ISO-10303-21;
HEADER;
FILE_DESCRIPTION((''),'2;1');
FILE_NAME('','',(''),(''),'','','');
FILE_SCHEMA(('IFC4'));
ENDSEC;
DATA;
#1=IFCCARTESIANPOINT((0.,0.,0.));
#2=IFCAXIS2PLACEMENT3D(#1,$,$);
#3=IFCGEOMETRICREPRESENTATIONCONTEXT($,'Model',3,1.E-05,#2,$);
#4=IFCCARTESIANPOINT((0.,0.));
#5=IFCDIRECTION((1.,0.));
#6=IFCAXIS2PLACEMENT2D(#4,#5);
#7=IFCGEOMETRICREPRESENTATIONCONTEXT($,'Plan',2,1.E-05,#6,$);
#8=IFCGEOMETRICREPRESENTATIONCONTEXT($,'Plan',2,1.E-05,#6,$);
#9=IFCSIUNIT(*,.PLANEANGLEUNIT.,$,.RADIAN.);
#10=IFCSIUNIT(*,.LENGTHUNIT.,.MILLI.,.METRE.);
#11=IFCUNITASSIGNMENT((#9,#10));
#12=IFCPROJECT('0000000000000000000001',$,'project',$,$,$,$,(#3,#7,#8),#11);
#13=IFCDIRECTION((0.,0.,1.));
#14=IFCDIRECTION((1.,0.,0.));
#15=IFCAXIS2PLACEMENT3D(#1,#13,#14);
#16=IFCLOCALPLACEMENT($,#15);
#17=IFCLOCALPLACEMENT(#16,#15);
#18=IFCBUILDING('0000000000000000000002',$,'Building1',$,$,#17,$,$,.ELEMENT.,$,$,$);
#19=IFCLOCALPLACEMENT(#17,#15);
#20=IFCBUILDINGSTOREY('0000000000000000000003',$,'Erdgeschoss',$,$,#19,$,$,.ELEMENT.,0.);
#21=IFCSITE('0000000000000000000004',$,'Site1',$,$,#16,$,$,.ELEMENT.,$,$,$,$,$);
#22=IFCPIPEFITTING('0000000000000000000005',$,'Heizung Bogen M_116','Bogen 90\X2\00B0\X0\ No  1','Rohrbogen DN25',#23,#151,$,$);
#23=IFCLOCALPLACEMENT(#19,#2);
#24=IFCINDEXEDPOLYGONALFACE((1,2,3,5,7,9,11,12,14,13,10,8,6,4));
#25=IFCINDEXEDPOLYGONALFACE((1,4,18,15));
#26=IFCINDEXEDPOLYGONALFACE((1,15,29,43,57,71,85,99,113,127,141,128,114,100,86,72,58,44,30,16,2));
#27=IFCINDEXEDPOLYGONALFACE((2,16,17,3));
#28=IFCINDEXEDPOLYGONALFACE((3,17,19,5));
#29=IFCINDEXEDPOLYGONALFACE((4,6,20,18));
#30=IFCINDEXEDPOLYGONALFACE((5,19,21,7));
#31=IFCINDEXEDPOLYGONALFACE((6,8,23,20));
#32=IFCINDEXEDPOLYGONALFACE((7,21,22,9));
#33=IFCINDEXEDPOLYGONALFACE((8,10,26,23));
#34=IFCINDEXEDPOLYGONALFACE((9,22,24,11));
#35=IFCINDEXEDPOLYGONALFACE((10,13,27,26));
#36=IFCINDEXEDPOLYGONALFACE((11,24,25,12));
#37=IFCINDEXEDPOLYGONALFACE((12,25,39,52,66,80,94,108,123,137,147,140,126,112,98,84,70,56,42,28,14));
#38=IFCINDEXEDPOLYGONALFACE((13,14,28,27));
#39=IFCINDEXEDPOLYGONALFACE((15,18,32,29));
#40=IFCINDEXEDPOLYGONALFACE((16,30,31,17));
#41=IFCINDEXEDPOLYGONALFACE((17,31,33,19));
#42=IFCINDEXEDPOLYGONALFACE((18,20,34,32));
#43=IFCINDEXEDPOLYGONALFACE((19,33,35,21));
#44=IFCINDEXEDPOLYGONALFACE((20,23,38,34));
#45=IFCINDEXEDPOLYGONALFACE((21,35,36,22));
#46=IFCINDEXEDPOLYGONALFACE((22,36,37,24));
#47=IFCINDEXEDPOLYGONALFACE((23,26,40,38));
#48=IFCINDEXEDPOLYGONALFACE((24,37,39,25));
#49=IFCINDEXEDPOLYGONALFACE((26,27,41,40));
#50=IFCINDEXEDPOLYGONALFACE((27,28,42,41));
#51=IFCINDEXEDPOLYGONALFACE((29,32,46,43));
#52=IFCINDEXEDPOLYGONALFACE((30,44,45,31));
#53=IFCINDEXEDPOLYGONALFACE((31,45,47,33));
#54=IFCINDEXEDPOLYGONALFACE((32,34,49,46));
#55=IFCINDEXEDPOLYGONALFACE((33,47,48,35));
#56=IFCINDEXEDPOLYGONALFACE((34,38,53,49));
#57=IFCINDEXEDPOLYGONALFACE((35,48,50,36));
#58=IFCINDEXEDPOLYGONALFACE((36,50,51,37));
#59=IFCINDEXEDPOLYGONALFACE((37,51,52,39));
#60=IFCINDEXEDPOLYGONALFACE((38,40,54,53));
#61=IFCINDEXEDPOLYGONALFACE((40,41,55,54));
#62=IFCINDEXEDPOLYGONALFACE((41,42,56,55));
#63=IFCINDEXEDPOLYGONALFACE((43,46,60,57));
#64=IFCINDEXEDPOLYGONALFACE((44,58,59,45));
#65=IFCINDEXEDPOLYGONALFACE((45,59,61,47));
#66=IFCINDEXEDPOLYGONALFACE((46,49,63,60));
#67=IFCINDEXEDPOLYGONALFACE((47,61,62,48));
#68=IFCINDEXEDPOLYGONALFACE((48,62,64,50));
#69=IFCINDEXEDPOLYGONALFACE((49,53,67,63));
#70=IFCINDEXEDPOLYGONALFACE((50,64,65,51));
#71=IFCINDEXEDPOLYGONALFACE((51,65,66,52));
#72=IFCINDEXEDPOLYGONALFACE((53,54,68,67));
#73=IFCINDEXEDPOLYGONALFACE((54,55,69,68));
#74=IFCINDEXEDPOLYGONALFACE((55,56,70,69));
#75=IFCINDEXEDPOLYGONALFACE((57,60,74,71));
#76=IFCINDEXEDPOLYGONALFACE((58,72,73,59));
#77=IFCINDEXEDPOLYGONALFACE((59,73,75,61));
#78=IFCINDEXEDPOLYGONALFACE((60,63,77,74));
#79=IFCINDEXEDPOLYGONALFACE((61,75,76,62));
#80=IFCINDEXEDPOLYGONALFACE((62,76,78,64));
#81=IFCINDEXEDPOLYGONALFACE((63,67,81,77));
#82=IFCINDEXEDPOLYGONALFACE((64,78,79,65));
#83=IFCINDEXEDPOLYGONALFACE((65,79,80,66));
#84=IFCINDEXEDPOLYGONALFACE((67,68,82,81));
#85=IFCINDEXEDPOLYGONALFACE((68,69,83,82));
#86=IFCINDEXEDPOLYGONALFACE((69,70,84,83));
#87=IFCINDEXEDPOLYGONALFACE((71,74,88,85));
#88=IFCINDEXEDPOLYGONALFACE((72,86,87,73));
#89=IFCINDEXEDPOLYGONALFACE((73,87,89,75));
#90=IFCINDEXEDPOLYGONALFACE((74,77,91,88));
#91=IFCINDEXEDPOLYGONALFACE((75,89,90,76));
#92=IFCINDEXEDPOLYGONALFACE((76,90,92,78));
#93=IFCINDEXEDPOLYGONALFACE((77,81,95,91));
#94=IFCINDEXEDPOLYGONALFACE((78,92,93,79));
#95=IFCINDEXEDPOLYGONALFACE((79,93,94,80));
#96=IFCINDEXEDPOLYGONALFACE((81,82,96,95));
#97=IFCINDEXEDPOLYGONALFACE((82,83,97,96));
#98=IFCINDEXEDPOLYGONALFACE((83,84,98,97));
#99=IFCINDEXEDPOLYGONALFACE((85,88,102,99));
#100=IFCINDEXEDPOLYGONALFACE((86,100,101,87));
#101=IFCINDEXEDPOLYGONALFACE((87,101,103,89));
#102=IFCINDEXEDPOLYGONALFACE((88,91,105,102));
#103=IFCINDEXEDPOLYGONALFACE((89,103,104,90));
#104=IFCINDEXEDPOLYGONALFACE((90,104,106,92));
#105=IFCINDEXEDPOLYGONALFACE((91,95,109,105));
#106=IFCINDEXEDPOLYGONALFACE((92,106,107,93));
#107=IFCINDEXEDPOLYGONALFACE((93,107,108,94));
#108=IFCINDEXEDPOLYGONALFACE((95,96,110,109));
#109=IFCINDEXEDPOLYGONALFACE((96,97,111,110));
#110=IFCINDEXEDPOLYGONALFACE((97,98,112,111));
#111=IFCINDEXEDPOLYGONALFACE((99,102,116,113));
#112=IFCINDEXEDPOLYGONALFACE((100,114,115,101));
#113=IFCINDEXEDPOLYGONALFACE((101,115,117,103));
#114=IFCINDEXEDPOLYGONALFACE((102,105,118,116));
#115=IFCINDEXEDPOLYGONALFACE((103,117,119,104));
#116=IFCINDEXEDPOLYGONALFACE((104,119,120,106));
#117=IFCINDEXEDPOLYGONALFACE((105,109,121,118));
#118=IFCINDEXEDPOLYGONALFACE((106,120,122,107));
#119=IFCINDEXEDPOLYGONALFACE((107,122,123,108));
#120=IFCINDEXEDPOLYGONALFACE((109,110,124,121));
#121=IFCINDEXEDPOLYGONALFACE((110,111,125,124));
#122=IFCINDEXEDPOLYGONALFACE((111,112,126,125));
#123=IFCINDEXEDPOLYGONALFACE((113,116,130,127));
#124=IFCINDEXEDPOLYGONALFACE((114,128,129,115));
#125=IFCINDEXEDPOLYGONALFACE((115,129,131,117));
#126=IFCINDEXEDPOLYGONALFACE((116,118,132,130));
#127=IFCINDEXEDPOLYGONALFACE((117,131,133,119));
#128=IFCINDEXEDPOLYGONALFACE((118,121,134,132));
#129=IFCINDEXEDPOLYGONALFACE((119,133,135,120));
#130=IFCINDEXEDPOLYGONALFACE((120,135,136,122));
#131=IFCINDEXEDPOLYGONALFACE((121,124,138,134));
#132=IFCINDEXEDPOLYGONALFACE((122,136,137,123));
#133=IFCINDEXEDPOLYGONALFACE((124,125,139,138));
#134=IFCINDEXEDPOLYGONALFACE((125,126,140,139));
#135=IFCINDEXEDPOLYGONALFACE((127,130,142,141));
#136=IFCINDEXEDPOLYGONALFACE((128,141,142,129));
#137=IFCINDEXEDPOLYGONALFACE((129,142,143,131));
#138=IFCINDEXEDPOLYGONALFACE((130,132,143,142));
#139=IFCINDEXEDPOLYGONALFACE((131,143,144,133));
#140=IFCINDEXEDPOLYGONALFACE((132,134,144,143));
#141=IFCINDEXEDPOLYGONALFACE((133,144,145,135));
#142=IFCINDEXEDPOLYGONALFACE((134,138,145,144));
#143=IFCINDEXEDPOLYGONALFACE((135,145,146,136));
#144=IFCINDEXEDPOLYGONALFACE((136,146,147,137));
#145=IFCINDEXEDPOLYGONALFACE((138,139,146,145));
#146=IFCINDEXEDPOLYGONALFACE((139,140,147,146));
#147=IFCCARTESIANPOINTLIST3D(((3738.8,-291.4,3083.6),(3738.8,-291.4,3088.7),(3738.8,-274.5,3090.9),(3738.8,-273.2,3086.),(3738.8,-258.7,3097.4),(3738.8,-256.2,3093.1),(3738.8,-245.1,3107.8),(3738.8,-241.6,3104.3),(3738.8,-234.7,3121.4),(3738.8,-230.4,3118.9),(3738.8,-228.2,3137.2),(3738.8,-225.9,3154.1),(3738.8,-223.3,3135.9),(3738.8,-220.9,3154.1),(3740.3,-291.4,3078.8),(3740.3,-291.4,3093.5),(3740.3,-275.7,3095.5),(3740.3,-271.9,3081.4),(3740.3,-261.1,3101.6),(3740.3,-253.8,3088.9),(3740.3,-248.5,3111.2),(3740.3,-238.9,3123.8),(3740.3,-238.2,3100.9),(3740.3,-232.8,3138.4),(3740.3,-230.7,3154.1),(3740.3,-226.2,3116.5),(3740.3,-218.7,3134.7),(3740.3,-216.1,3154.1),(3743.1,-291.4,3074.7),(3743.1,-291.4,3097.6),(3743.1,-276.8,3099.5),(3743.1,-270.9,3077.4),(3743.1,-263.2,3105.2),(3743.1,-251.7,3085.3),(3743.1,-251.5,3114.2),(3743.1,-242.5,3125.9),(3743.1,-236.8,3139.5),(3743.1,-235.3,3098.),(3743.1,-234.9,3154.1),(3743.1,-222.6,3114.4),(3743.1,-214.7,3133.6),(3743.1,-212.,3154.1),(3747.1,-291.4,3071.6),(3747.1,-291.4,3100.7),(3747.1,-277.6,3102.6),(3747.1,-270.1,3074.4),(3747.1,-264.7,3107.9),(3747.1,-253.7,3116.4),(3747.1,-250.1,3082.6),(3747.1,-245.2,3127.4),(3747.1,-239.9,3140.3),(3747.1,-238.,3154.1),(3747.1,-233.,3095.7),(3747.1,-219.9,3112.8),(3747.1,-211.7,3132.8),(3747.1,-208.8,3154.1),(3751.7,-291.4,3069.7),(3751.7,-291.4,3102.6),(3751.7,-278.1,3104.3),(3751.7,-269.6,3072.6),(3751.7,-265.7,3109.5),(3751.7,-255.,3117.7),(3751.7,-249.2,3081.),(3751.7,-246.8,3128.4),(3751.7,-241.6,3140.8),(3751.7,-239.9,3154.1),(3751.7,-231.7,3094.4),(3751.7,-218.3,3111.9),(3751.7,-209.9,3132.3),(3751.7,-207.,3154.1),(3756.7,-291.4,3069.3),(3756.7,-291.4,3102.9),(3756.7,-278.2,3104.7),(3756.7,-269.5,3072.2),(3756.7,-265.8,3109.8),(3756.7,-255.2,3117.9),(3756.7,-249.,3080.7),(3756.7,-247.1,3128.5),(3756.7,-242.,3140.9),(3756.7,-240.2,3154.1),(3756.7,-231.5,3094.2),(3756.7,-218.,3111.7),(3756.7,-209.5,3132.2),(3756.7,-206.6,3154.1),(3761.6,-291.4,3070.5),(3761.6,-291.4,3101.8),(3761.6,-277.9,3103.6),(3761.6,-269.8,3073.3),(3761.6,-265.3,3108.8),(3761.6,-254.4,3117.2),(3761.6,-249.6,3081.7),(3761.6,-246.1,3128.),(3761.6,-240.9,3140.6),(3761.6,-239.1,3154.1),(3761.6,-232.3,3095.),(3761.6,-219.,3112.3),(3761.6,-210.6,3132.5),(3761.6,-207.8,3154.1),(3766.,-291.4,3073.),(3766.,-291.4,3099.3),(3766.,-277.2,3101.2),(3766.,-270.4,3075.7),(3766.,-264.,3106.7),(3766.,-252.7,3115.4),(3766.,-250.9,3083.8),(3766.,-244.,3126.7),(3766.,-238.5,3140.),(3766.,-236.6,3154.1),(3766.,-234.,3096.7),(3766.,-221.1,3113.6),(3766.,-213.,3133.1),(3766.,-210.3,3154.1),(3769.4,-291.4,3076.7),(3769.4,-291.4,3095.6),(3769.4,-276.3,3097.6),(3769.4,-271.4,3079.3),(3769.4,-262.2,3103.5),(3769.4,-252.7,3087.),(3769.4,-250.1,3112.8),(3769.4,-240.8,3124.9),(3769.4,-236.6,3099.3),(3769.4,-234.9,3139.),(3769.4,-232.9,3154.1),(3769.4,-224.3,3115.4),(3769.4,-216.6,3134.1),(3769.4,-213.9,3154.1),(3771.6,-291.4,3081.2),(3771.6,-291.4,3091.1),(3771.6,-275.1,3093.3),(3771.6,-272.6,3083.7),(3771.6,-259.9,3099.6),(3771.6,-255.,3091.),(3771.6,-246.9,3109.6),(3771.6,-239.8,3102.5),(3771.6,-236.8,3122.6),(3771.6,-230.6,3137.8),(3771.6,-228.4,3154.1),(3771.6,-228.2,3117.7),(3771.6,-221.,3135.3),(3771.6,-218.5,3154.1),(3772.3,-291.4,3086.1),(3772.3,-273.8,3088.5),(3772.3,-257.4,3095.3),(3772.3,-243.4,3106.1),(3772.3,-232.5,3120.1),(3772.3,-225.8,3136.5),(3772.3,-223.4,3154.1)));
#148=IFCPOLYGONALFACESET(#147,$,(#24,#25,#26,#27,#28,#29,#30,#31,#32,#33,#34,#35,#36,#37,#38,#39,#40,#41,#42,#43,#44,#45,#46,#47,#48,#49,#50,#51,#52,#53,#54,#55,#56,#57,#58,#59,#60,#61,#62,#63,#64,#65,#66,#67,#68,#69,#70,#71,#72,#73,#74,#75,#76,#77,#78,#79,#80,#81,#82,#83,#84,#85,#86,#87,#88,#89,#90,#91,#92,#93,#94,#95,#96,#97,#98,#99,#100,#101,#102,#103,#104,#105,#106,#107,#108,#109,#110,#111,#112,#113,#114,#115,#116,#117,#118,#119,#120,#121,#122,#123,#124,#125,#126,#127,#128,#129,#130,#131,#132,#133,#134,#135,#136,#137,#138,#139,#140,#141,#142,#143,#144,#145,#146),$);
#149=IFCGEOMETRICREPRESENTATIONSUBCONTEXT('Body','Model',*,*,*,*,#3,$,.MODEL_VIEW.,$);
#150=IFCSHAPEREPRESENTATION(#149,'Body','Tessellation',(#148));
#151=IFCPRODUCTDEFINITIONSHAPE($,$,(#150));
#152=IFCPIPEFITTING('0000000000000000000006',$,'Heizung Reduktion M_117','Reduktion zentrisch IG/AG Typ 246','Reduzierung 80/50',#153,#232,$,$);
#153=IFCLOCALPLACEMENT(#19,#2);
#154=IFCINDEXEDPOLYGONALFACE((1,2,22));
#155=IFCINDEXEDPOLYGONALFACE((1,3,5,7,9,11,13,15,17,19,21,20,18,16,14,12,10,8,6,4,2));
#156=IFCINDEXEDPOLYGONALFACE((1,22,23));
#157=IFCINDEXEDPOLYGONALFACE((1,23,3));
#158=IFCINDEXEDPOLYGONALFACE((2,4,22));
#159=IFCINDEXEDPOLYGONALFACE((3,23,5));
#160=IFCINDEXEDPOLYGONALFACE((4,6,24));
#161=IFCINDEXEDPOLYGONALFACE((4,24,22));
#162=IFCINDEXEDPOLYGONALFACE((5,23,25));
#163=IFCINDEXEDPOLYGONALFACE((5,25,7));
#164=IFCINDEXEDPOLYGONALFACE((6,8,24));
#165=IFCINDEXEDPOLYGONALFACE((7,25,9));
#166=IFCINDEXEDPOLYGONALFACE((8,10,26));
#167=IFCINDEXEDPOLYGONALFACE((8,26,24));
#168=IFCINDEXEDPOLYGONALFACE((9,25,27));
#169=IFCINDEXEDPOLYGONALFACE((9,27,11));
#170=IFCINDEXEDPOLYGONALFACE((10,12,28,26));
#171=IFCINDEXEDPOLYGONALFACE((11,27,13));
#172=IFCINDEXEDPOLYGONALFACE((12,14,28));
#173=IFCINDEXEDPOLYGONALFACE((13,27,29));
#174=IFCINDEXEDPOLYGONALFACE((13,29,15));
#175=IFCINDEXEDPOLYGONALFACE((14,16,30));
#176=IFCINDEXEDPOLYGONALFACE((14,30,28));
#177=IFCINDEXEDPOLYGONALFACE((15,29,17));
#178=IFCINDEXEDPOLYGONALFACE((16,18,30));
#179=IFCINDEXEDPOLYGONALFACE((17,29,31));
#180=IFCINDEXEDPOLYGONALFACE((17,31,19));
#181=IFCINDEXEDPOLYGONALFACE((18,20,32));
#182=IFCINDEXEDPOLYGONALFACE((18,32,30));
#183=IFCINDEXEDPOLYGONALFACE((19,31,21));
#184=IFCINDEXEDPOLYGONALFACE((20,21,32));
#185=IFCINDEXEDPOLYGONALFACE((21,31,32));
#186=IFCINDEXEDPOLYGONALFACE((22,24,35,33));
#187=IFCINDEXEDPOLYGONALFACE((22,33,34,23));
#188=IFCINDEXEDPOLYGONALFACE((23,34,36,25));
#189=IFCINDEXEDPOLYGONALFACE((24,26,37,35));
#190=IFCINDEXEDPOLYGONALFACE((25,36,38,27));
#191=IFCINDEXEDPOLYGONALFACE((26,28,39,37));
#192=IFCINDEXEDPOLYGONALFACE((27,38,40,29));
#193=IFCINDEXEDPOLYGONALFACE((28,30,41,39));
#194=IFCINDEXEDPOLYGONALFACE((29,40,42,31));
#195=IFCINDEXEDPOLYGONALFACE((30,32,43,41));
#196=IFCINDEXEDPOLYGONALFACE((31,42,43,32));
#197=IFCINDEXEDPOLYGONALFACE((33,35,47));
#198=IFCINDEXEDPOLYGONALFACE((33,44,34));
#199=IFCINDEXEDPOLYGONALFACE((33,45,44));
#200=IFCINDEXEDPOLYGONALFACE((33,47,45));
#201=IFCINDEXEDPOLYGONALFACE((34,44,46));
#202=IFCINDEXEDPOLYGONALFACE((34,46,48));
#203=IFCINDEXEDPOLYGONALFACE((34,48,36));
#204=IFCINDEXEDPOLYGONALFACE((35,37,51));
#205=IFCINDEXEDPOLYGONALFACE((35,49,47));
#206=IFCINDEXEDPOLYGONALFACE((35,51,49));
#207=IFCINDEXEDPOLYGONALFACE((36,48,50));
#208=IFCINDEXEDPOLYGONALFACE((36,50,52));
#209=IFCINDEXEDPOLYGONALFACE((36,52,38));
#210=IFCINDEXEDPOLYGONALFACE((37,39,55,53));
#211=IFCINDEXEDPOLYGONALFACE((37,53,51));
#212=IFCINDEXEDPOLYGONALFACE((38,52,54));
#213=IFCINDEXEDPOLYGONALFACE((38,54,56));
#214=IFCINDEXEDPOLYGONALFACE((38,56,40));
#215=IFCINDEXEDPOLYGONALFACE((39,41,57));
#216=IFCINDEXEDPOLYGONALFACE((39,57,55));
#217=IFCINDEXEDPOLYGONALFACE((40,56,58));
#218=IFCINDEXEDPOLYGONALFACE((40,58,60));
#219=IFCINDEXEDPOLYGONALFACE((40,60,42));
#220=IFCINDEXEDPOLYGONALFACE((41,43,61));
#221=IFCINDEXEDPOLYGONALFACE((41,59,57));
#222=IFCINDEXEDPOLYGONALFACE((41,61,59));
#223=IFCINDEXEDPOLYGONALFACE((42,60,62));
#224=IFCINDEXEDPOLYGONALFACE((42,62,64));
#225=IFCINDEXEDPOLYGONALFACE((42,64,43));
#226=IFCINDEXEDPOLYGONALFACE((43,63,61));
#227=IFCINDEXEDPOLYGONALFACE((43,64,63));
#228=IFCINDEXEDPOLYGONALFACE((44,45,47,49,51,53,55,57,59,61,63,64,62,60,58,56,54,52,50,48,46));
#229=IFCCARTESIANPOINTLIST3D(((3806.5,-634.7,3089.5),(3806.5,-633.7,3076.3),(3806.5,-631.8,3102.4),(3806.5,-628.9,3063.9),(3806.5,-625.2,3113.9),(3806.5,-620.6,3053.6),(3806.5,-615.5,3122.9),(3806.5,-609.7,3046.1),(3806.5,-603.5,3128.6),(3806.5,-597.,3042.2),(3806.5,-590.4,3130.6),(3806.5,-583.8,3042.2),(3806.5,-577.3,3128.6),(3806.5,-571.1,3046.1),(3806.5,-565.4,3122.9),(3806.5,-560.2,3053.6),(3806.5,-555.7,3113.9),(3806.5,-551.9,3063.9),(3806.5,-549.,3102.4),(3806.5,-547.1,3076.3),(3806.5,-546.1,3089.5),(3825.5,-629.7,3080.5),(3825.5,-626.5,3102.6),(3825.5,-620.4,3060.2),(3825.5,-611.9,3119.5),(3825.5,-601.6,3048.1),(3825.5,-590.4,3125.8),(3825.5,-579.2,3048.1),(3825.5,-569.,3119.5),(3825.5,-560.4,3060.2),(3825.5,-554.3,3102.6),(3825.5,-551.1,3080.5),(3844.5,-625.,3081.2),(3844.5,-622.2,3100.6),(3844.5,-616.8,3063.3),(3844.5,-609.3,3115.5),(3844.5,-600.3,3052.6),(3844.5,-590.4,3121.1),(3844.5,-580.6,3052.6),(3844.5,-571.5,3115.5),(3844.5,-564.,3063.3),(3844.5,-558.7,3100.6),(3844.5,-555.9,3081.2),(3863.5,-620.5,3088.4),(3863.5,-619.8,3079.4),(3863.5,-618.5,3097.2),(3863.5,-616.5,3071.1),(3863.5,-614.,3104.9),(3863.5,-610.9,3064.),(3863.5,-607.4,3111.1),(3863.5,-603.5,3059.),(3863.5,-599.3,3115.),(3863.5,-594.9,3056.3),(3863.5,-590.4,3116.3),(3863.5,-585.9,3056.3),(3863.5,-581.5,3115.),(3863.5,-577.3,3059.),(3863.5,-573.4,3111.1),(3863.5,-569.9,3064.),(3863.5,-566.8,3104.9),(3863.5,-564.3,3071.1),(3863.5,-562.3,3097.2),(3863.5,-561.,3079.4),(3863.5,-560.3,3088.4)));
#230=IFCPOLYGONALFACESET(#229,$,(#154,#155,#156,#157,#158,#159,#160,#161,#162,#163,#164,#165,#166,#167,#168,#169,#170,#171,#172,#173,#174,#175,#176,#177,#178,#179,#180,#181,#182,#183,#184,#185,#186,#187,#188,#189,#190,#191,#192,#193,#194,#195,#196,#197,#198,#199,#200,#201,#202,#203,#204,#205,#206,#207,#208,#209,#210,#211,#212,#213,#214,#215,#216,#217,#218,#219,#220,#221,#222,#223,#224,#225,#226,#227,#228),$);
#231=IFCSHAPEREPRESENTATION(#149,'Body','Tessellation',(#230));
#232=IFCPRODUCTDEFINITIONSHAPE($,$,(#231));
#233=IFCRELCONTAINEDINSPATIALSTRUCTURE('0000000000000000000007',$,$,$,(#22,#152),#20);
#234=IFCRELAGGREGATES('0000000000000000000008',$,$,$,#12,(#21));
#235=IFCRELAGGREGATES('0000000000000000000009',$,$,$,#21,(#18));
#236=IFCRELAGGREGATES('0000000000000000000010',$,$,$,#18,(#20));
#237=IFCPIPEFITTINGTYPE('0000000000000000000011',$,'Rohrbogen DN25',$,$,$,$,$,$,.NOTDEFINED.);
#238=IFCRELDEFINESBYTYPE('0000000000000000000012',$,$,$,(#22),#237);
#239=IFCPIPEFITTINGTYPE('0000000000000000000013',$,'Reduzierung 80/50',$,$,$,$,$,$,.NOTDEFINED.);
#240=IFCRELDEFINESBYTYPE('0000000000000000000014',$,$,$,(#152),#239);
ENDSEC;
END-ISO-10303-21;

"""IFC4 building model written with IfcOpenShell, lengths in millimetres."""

from ifc_helpers import new_model, entity, si_unit, frame, origin, origin_with_axes, origin_2d_with_axis, place, context, subcontext, project, spatial, source, transform, mapped, type_object, element, save


model = new_model("IFC4")

# Units and contexts
model_context = context("Model", 3, precision=1e-05, world=origin())
plan_context_1 = context("Plan", 2, precision=1e-05, world=origin_2d_with_axis())
plan_context_2 = context("Plan", 2, precision=1e-05, world=origin_2d_with_axis())
body_context = subcontext(model_context, "Body", "Model", "MODEL_VIEW")
ifc_project = project(units=[si_unit("PLANEANGLEUNIT", "RADIAN"), si_unit("LENGTHUNIT", "METRE", prefix="MILLI")], contexts=[model_context, plan_context_1, plan_context_2])

# Site, building, storey
site_placement = place(None, origin_with_axes())
site = spatial("IfcSite", under=ifc_project, at=site_placement, Name="Site1", CompositionType="ELEMENT")
building_placement = place(site_placement, origin_with_axes())
building = spatial("IfcBuilding", under=site, at=building_placement, Name="Building1", CompositionType="ELEMENT")
storey_placement = place(building_placement, origin_with_axes())
storey = spatial("IfcBuildingStorey", under=building, at=storey_placement, Name="Erdgeschoss", CompositionType="ELEMENT", Elevation=0.0)

# Shared definitions
pipe_fitting_type_1 = type_object("IfcPipeFittingType", Name="Rohrbogen DN25", PredefinedType="NOTDEFINED")

# Pipe fittings
shared_shape_1 = source(origin_with_axes(), body_context, "Body", "SolidModel", [
    entity("IfcRevolvedAreaSolid", entity("IfcCircleProfileDef", "AREA", None, entity("IfcAxis2Placement2D", entity("IfcCartesianPoint", [0.0, 0.0]), entity("IfcDirection", [1.0, 0.0])), 16.9), entity("IfcAxis2Placement3D", entity("IfcCartesianPoint", [42.4, 25.6, 0.0]), entity("IfcDirection", [-1.0, 0.0, 0.0]), entity("IfcDirection", [0.0, 0.0, -1.0])), entity("IfcAxis1Placement", entity("IfcCartesianPoint", [0.0, 68.0, 0.0]), entity("IfcDirection", [-1.0, 0.0, 0.0])), 1.570796),
])
pipe_fitting_1_placement = place(storey_placement, frame((3755.5, -249.0, 3111.7), z_axis=(0.0, 0.0, 1.0), x_axis=(1.0, 0.0, 0.0)))
element("IfcPipeFitting", 1, at=pipe_fitting_1_placement, inside=storey, type_object=pipe_fitting_type_1, Name="Heizung Bogen M_116", Description="Bogen 90° No  1", ObjectType="Rohrbogen DN25", context=body_context, shape_type="MappedRepresentation", body=[
    mapped(shared_shape_1, transform((0.0, 0.0, 0.0), x_axis=(0.0, 0.0, 1.0), y_axis=(0.0, 1.0, 0.0), z_axis=(-1.0, 0.0, 0.0), scale=1.0)),
])
pipe_fitting_type_2 = type_object("IfcPipeFittingType", Name="Reduzierung 80/50", PredefinedType="NOTDEFINED")
axis2_placement2_d = entity("IfcAxis2Placement2D", entity("IfcCartesianPoint", [0.0, 0.0]), entity("IfcDirection", [1.0, 0.0]))
shared_shape_2 = source(origin_with_axes(), body_context, "Body", "SolidModel", [
    entity("IfcExtrudedAreaSolidTapered", entity("IfcCircleProfileDef", "AREA", None, axis2_placement2_d, 44.5), entity("IfcAxis2Placement3D", entity("IfcCartesianPoint", [-28.5, -0.1, 0.0]), entity("IfcDirection", [1.0, 0.0, 0.0]), entity("IfcDirection", [0.0, 0.0, 1.0])), entity("IfcDirection", [0.0, 0.0, 1.0]), 57.0, entity("IfcCircleProfileDef", "AREA", None, axis2_placement2_d, 30.1)),
])
pipe_fitting_2_placement = place(storey_placement, frame((3835.0, -590.3, 3086.1), z_axis=(0.0, 0.0, 1.0), x_axis=(1.0, 0.0, 0.0)))
element("IfcPipeFitting", 2, at=pipe_fitting_2_placement, inside=storey, type_object=pipe_fitting_type_2, Name="Heizung Reduktion M_117", Description="Reduktion zentrisch IG/AG Typ 246", ObjectType="Reduzierung 80/50", context=body_context, shape_type="MappedRepresentation", body=[
    mapped(shared_shape_2, transform((0.0, 0.0, 0.0), x_axis=(1.0, 0.0, 0.0), y_axis=(0.0, 1.0, 0.0), z_axis=(0.0, 0.0, 1.0), scale=1.0)),
])

save(model, "model.ifc")
